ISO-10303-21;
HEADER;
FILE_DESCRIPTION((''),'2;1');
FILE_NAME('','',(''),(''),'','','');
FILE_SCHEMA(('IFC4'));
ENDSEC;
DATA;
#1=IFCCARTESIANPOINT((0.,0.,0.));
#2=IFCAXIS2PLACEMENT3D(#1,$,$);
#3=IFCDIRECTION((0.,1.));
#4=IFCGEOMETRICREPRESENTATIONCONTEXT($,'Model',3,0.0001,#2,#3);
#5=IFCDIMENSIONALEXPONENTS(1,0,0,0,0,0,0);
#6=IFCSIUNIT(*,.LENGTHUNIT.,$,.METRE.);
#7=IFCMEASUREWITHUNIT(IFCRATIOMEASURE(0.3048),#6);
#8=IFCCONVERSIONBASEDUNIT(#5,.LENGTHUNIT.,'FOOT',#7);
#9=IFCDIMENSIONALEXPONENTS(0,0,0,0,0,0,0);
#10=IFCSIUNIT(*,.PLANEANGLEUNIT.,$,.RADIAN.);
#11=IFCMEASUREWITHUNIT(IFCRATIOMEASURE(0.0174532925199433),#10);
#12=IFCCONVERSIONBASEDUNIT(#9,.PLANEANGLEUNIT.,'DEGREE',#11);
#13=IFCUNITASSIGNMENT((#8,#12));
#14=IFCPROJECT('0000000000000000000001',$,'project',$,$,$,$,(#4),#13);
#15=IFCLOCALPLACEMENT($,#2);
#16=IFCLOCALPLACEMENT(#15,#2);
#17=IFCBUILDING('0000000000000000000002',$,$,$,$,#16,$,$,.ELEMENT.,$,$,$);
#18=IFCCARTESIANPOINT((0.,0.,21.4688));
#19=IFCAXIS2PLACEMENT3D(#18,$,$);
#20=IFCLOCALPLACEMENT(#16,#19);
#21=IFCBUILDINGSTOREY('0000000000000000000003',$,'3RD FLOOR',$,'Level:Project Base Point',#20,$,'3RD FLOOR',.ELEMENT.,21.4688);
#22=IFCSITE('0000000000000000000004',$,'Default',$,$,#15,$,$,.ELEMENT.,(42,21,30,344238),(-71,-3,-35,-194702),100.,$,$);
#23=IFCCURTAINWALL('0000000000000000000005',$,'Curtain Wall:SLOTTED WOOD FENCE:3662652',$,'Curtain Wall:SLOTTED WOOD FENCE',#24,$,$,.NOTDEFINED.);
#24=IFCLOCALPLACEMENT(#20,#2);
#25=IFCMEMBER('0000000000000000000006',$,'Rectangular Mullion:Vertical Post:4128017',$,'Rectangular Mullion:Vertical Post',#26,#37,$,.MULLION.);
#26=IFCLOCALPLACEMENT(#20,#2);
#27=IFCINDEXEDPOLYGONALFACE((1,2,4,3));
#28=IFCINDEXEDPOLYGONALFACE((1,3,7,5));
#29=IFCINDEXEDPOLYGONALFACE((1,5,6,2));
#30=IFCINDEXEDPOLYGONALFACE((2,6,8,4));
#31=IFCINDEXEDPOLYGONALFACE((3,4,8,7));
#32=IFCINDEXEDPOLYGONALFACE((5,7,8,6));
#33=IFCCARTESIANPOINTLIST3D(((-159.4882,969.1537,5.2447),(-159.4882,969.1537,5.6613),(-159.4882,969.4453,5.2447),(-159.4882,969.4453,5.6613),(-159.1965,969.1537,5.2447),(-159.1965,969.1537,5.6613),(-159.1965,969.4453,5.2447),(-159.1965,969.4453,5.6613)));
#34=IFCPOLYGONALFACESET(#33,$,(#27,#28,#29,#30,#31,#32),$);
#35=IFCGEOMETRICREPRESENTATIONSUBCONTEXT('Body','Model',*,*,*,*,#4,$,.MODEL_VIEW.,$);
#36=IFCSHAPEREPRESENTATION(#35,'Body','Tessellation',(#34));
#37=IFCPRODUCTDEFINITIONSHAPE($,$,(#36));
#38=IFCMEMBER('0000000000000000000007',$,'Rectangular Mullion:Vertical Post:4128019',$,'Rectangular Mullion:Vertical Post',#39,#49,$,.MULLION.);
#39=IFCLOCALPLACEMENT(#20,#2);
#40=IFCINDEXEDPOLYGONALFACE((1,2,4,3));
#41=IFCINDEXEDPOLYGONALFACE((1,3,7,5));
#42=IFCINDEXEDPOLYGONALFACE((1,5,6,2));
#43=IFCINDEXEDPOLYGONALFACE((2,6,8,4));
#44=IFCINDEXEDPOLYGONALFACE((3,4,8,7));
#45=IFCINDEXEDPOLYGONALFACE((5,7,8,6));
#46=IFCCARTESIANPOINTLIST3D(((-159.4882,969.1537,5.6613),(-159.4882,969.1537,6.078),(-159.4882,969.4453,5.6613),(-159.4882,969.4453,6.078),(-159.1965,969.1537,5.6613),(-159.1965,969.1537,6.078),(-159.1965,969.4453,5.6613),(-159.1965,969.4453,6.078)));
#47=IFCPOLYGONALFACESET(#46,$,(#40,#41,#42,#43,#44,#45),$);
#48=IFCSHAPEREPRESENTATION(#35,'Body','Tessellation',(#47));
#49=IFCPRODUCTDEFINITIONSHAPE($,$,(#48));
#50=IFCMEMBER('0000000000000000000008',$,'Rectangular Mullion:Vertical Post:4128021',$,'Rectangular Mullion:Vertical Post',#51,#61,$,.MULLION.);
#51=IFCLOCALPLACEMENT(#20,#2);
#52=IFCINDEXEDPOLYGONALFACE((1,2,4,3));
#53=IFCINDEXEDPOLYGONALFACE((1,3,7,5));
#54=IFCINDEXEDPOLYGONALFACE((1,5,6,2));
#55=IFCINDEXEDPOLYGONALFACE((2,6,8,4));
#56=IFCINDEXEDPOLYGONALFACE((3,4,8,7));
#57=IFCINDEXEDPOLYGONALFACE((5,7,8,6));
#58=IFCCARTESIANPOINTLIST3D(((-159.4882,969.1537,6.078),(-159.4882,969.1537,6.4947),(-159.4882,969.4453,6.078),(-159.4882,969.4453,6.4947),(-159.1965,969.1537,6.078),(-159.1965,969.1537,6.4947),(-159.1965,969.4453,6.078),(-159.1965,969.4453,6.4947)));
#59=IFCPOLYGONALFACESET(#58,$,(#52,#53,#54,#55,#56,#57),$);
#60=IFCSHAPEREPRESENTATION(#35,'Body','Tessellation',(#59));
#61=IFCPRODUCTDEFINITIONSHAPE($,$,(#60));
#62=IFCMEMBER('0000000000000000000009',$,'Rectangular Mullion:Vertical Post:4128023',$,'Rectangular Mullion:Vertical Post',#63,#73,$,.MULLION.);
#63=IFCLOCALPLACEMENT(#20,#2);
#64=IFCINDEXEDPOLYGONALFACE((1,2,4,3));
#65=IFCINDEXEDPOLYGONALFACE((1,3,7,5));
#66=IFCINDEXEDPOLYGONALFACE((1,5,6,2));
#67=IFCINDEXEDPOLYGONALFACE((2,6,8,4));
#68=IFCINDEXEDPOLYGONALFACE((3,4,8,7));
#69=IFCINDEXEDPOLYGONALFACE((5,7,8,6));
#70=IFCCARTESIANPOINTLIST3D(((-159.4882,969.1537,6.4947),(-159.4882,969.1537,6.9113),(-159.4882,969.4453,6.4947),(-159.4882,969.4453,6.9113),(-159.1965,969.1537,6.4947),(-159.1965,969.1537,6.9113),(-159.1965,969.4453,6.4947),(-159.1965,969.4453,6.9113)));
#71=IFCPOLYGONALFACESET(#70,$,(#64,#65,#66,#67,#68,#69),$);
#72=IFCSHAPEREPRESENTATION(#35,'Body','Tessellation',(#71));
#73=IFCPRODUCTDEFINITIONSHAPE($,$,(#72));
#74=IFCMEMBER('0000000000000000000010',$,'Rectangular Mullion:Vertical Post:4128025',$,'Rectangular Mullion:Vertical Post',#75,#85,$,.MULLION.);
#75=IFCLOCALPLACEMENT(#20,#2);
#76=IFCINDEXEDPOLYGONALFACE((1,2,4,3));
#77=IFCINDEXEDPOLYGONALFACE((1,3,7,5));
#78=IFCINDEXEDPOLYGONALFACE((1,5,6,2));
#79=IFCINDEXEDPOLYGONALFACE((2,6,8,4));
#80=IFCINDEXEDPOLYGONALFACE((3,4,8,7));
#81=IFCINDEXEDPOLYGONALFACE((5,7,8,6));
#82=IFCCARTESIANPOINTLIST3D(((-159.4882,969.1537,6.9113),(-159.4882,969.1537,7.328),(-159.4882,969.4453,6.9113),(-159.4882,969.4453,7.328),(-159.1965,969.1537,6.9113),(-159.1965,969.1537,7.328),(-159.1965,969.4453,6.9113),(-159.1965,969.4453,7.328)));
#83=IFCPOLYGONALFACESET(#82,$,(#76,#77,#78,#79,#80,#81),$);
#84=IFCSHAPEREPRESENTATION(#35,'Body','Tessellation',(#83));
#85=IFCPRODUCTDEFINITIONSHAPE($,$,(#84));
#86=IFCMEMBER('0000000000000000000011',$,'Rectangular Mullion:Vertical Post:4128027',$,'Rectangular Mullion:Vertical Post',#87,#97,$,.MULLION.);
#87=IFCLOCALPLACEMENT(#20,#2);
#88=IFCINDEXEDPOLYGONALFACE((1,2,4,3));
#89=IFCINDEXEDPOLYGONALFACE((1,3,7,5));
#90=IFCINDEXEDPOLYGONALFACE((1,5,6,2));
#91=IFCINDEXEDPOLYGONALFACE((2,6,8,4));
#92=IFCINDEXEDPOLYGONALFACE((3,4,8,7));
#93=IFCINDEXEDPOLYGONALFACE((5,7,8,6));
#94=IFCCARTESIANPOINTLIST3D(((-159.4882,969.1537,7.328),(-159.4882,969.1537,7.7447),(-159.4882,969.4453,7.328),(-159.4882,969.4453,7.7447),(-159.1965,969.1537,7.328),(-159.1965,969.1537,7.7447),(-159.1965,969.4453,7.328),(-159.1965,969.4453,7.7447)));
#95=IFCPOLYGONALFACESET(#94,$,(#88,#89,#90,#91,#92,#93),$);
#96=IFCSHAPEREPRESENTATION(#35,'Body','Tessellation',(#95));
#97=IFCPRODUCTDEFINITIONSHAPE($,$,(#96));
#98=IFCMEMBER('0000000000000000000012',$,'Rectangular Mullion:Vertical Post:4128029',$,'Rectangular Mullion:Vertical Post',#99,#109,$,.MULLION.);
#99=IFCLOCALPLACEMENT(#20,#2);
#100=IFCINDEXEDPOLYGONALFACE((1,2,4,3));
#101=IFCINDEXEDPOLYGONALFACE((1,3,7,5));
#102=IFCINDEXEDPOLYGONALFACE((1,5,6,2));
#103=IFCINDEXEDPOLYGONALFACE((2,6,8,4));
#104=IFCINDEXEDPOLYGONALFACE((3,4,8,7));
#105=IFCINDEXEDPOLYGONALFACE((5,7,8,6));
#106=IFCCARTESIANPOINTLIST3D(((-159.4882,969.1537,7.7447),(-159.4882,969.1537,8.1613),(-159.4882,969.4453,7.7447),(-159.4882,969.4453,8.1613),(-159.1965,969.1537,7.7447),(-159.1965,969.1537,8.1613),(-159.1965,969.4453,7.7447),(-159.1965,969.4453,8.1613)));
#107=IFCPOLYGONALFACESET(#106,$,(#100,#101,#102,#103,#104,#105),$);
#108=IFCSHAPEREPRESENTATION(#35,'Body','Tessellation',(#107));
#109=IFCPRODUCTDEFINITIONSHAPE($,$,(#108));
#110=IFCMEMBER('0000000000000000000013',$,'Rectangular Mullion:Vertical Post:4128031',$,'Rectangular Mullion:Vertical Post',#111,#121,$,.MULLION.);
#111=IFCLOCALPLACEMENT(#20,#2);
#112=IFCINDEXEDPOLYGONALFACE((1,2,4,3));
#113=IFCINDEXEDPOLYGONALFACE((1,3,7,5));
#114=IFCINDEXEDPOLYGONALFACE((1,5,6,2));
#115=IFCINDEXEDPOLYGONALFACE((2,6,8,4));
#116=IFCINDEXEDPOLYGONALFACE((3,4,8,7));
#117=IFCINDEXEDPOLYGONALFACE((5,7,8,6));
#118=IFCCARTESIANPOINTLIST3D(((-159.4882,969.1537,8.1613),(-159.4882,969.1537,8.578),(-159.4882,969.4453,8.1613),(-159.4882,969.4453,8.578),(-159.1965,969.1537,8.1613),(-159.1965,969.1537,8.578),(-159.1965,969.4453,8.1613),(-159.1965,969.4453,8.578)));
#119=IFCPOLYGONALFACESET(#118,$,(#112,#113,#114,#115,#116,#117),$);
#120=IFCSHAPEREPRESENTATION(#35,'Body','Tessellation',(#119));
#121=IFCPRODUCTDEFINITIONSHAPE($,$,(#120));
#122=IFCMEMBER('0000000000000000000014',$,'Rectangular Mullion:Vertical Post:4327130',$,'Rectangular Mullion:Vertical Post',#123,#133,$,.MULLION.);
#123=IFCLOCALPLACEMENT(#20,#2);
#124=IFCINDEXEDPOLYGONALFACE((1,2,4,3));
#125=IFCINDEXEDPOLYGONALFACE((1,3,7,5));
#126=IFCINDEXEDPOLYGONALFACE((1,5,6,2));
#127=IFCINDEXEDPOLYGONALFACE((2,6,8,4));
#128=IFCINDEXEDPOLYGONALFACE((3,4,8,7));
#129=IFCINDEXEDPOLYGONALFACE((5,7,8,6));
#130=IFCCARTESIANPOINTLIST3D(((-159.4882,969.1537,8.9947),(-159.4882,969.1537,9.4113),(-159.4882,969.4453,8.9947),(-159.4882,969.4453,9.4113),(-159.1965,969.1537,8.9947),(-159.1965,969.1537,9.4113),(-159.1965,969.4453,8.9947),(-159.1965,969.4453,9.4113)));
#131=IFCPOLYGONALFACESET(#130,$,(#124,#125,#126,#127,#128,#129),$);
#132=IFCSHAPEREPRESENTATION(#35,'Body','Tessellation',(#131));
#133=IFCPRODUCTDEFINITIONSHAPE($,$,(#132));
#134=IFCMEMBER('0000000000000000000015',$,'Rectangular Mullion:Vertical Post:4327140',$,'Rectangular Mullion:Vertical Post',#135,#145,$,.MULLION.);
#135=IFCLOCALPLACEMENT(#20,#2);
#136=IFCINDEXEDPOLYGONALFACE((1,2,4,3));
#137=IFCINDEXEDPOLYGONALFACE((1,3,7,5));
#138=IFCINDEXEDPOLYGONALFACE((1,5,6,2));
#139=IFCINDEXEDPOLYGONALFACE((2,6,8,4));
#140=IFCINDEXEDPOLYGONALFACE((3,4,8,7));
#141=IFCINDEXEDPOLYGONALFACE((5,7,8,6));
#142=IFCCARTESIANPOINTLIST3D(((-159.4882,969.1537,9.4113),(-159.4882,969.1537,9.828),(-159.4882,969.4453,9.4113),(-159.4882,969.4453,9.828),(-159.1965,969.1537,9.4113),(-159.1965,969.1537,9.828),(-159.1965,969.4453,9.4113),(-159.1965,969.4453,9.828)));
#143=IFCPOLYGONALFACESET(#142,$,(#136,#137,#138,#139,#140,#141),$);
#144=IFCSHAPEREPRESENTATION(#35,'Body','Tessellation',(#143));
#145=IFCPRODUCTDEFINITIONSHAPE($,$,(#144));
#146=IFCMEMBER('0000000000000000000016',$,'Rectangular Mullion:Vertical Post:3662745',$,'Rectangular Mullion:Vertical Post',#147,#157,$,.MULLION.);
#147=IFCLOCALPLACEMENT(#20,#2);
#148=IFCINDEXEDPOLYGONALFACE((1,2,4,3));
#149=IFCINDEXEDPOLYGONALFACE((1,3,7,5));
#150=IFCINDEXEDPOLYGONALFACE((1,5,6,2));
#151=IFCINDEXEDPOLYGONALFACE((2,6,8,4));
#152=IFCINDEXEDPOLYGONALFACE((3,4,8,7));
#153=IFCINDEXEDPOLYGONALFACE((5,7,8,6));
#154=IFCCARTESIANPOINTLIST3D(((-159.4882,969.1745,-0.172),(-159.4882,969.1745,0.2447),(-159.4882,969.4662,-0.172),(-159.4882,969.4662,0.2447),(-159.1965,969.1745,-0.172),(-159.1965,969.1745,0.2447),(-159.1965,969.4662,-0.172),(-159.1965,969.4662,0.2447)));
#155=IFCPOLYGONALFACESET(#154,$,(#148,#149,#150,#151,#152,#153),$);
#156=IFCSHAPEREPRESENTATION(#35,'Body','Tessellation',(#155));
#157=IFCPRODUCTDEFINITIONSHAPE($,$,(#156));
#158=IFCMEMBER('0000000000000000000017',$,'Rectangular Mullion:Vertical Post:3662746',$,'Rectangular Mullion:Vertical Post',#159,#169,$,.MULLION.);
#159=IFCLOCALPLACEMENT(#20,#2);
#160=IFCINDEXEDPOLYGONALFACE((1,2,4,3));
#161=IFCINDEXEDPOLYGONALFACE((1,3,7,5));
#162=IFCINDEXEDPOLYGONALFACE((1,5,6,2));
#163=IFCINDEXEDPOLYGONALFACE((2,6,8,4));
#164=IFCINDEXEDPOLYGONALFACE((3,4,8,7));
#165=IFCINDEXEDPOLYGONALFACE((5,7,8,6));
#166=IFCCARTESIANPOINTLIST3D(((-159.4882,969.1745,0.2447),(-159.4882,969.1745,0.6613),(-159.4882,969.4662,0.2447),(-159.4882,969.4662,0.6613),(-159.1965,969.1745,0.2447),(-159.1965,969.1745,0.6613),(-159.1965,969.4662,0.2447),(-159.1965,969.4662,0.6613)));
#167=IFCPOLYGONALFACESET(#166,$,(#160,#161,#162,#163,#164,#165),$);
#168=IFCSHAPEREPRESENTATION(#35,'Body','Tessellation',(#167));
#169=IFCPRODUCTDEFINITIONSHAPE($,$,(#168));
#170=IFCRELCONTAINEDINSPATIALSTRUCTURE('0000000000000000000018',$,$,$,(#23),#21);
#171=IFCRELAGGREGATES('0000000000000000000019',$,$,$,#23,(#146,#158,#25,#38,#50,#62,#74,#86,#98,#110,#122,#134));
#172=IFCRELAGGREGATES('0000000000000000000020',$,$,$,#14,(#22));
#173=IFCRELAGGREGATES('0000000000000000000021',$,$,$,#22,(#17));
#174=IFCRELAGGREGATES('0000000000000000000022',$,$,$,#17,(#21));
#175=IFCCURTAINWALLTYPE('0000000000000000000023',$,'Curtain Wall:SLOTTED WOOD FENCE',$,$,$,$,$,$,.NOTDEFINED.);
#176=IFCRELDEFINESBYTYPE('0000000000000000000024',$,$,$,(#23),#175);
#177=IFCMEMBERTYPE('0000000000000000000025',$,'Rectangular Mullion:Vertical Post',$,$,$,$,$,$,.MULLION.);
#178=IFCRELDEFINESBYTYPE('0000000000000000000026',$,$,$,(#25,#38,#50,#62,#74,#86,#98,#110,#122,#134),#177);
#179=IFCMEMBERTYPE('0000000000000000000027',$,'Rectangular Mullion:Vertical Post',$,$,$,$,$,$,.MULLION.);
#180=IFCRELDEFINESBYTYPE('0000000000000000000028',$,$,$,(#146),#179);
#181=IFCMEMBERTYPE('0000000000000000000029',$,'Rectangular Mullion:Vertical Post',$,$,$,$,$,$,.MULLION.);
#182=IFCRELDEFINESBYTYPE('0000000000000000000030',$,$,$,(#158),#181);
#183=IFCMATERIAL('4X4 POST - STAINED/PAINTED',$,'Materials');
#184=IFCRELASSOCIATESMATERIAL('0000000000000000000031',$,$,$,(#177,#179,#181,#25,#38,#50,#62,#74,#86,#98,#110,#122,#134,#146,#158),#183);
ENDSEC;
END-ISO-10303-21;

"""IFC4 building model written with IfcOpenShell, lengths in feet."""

from ifc_helpers import new_model, entity, si_unit, converted_unit, direction, frame, origin, origin_2d_with_axis, place, context, subcontext, project, spatial, rectangle, extrude, source, transform, mapped, material, material_profile, profile_set, profile_usage, type_object, type_shapes, element, aggregate, save


model = new_model("IFC4")

# Units and contexts
model_context = context("Model", 3, precision=0.0001, world=origin(), true_north=direction((0.0, 1.0)))
body_context = subcontext(model_context, "Body", "Model", "MODEL_VIEW")
ifc_project = project(units=[converted_unit("LENGTHUNIT", "FOOT", entity("IfcRatioMeasure", 0.3048), si_unit("LENGTHUNIT", "METRE"), dimensions=[1, 0, 0, 0, 0, 0, 0]), converted_unit("PLANEANGLEUNIT", "DEGREE", entity("IfcRatioMeasure", 0.0174532925199433), si_unit("PLANEANGLEUNIT", "RADIAN"), dimensions=[0, 0, 0, 0, 0, 0, 0])], contexts=[model_context])

# Site, building, storey
site_placement = place(None, origin())
site = spatial("IfcSite", under=ifc_project, at=site_placement, Name="Default", CompositionType="ELEMENT", RefLatitude=(42, 21, 30, 344238), RefLongitude=(-71, -3, -35, -194702), RefElevation=100.0)
building_placement = place(site_placement, origin())
building = spatial("IfcBuilding", under=site, at=building_placement, CompositionType="ELEMENT")
storey_placement = place(building_placement, frame((0.0, 0.0, 21.4688)))
storey = spatial("IfcBuildingStorey", under=building, at=storey_placement, Name="3RD FLOOR", ObjectType="Level:Project Base Point", LongName="3RD FLOOR", CompositionType="ELEMENT", Elevation=21.4688)

# Curtain wall, members
curtain_wall_type = type_object("IfcCurtainWallType", Name="Curtain Wall:SLOTTED WOOD FENCE", PredefinedType="NOTDEFINED")
curtain_wall_placement = place(storey_placement, frame((0.0, 0.0, -21.4688)))
curtain_wall = element("IfcCurtainWall", 1, at=curtain_wall_placement, inside=storey, type_object=curtain_wall_type, Name="Curtain Wall:SLOTTED WOOD FENCE:3662652", ObjectType="Curtain Wall:SLOTTED WOOD FENCE", PredefinedType="NOTDEFINED")
ifc_material = material(Name="4X4 POST - STAINED/PAINTED", Category="Materials")
ifc_material_profile = material_profile(ifc_material, rectangle(XDim=0.2917, YDim=0.2917, at=origin_2d_with_axis()), Name="Vertical Post")
ifc_profile_set = profile_set([ifc_material_profile], Name="Vertical Post")
member_type_1 = type_object("IfcMemberType", Name="Rectangular Mullion:Vertical Post", PredefinedType="MULLION", material=ifc_profile_set)
shared_shape_1 = source(origin(), body_context, "Body", "SweptSolid", [
    extrude(rectangle(XDim=0.2917, YDim=0.2917, at=origin_2d_with_axis()), frame((0.0, -0.2083, -0.4167), z_axis=(0.0, 0.0, 1.0), x_axis=(0.0, -1.0, 0.0)), (0.0, 0.0, 1.0), 0.4167),
])
type_shapes(member_type_1, [shared_shape_1])
ifc_profile_usage_1 = profile_usage(ifc_profile_set)
member_1_placement = place(storey_placement, frame((-159.5507, 969.2995, 5.2447), z_axis=(0.0, 0.0, -1.0), x_axis=(0.0, -1.0, 0.0)))
member_1 = element("IfcMember", 2, at=member_1_placement, type_object=member_type_1, material=ifc_profile_usage_1, Name="Rectangular Mullion:Vertical Post:4128017", ObjectType="Rectangular Mullion:Vertical Post", PredefinedType="MULLION", context=body_context, shape_type="MappedRepresentation", body=[
    mapped(shared_shape_1, transform((0.0, 0.0, 0.0), scale=1.0)),
])
ifc_profile_usage_2 = profile_usage(ifc_profile_set)
member_2_placement = place(storey_placement, frame((-159.5507, 969.2995, 5.6613), z_axis=(0.0, 0.0, -1.0), x_axis=(0.0, -1.0, 0.0)))
member_2 = element("IfcMember", 3, at=member_2_placement, type_object=member_type_1, material=ifc_profile_usage_2, Name="Rectangular Mullion:Vertical Post:4128019", ObjectType="Rectangular Mullion:Vertical Post", PredefinedType="MULLION", context=body_context, shape_type="MappedRepresentation", body=[
    mapped(shared_shape_1, transform((0.0, 0.0, 0.0), scale=1.0)),
])
ifc_profile_usage_3 = profile_usage(ifc_profile_set)
member_3_placement = place(storey_placement, frame((-159.5507, 969.2995, 6.078), z_axis=(0.0, 0.0, -1.0), x_axis=(0.0, -1.0, 0.0)))
member_3 = element("IfcMember", 4, at=member_3_placement, type_object=member_type_1, material=ifc_profile_usage_3, Name="Rectangular Mullion:Vertical Post:4128021", ObjectType="Rectangular Mullion:Vertical Post", PredefinedType="MULLION", context=body_context, shape_type="MappedRepresentation", body=[
    mapped(shared_shape_1, transform((0.0, 0.0, 0.0), scale=1.0)),
])
ifc_profile_usage_4 = profile_usage(ifc_profile_set)
member_4_placement = place(storey_placement, frame((-159.5507, 969.2995, 6.4947), z_axis=(0.0, 0.0, -1.0), x_axis=(0.0, -1.0, 0.0)))
member_4 = element("IfcMember", 5, at=member_4_placement, type_object=member_type_1, material=ifc_profile_usage_4, Name="Rectangular Mullion:Vertical Post:4128023", ObjectType="Rectangular Mullion:Vertical Post", PredefinedType="MULLION", context=body_context, shape_type="MappedRepresentation", body=[
    mapped(shared_shape_1, transform((0.0, 0.0, 0.0), scale=1.0)),
])
ifc_profile_usage_5 = profile_usage(ifc_profile_set)
member_5_placement = place(storey_placement, frame((-159.5507, 969.2995, 6.9113), z_axis=(0.0, 0.0, -1.0), x_axis=(0.0, -1.0, 0.0)))
member_5 = element("IfcMember", 6, at=member_5_placement, type_object=member_type_1, material=ifc_profile_usage_5, Name="Rectangular Mullion:Vertical Post:4128025", ObjectType="Rectangular Mullion:Vertical Post", PredefinedType="MULLION", context=body_context, shape_type="MappedRepresentation", body=[
    mapped(shared_shape_1, transform((0.0, 0.0, 0.0), scale=1.0)),
])
ifc_profile_usage_6 = profile_usage(ifc_profile_set)
member_6_placement = place(storey_placement, frame((-159.5507, 969.2995, 7.328), z_axis=(0.0, 0.0, -1.0), x_axis=(0.0, -1.0, 0.0)))
member_6 = element("IfcMember", 7, at=member_6_placement, type_object=member_type_1, material=ifc_profile_usage_6, Name="Rectangular Mullion:Vertical Post:4128027", ObjectType="Rectangular Mullion:Vertical Post", PredefinedType="MULLION", context=body_context, shape_type="MappedRepresentation", body=[
    mapped(shared_shape_1, transform((0.0, 0.0, 0.0), scale=1.0)),
])
ifc_profile_usage_7 = profile_usage(ifc_profile_set)
member_7_placement = place(storey_placement, frame((-159.5507, 969.2995, 7.7447), z_axis=(0.0, 0.0, -1.0), x_axis=(0.0, -1.0, 0.0)))
member_7 = element("IfcMember", 8, at=member_7_placement, type_object=member_type_1, material=ifc_profile_usage_7, Name="Rectangular Mullion:Vertical Post:4128029", ObjectType="Rectangular Mullion:Vertical Post", PredefinedType="MULLION", context=body_context, shape_type="MappedRepresentation", body=[
    mapped(shared_shape_1, transform((0.0, 0.0, 0.0), scale=1.0)),
])
ifc_profile_usage_8 = profile_usage(ifc_profile_set)
member_8_placement = place(storey_placement, frame((-159.5507, 969.2995, 8.1613), z_axis=(0.0, 0.0, -1.0), x_axis=(0.0, -1.0, 0.0)))
member_8 = element("IfcMember", 9, at=member_8_placement, type_object=member_type_1, material=ifc_profile_usage_8, Name="Rectangular Mullion:Vertical Post:4128031", ObjectType="Rectangular Mullion:Vertical Post", PredefinedType="MULLION", context=body_context, shape_type="MappedRepresentation", body=[
    mapped(shared_shape_1, transform((0.0, 0.0, 0.0), scale=1.0)),
])
ifc_profile_usage_9 = profile_usage(ifc_profile_set)
member_9_placement = place(storey_placement, frame((-159.5507, 969.2995, 8.9947), z_axis=(0.0, 0.0, -1.0), x_axis=(0.0, -1.0, 0.0)))
member_9 = element("IfcMember", 10, at=member_9_placement, type_object=member_type_1, material=ifc_profile_usage_9, Name="Rectangular Mullion:Vertical Post:4327130", ObjectType="Rectangular Mullion:Vertical Post", PredefinedType="MULLION", context=body_context, shape_type="MappedRepresentation", body=[
    mapped(shared_shape_1, transform((0.0, 0.0, 0.0), scale=1.0)),
])
ifc_profile_usage_10 = profile_usage(ifc_profile_set)
member_10_placement = place(storey_placement, frame((-159.5507, 969.2995, 9.4113), z_axis=(0.0, 0.0, -1.0), x_axis=(0.0, -1.0, 0.0)))
member_10 = element("IfcMember", 11, at=member_10_placement, type_object=member_type_1, material=ifc_profile_usage_10, Name="Rectangular Mullion:Vertical Post:4327140", ObjectType="Rectangular Mullion:Vertical Post", PredefinedType="MULLION", context=body_context, shape_type="MappedRepresentation", body=[
    mapped(shared_shape_1, transform((0.0, 0.0, 0.0), scale=1.0)),
])
ifc_profile_usage_11 = profile_usage(ifc_profile_set)
member_type_2 = type_object("IfcMemberType", Name="Rectangular Mullion:Vertical Post", PredefinedType="MULLION", material=ifc_profile_set)
shared_shape_2 = source(origin(), body_context, "Body", "SweptSolid", [
    extrude(rectangle(XDim=0.2917, YDim=0.2917, at=origin_2d_with_axis()), frame((-0.1458, -0.2083, -0.4167), z_axis=(0.0, 0.0, 1.0), x_axis=(0.0, -1.0, 0.0)), (0.0, 0.0, 1.0), 0.4167),
])
type_shapes(member_type_2, [shared_shape_2])
member_11_placement = place(storey_placement, frame((-159.5507, 969.4662, 0.2447), z_axis=(0.0, 0.0, 1.0), x_axis=(0.0, 1.0, 0.0)))
member_11 = element("IfcMember", 12, at=member_11_placement, type_object=member_type_2, material=ifc_profile_usage_11, Name="Rectangular Mullion:Vertical Post:3662745", ObjectType="Rectangular Mullion:Vertical Post", PredefinedType="MULLION", context=body_context, shape_type="MappedRepresentation", body=[
    mapped(shared_shape_2, transform((0.0, 0.0, 0.0), scale=1.0)),
])
ifc_profile_usage_12 = profile_usage(ifc_profile_set)
member_type_3 = type_object("IfcMemberType", Name="Rectangular Mullion:Vertical Post", PredefinedType="MULLION", material=ifc_profile_set)
shared_shape_3 = source(origin(), body_context, "Body", "SweptSolid", [
    extrude(rectangle(XDim=0.2917, YDim=0.2917, at=origin_2d_with_axis()), frame((-0.1458, -0.2083, -0.4167), z_axis=(0.0, 0.0, 1.0), x_axis=(0.0, -1.0, 0.0)), (0.0, 0.0, 1.0), 0.4167),
])
type_shapes(member_type_3, [shared_shape_3])
member_12_placement = place(storey_placement, frame((-159.5507, 969.4662, 0.6613), z_axis=(0.0, 0.0, 1.0), x_axis=(0.0, 1.0, 0.0)))
member_12 = element("IfcMember", 13, at=member_12_placement, type_object=member_type_3, material=ifc_profile_usage_12, Name="Rectangular Mullion:Vertical Post:3662746", ObjectType="Rectangular Mullion:Vertical Post", PredefinedType="MULLION", context=body_context, shape_type="MappedRepresentation", body=[
    mapped(shared_shape_3, transform((0.0, 0.0, 0.0), scale=1.0)),
])
aggregate(curtain_wall, [member_11, member_12, member_1, member_2, member_3, member_4, member_5, member_6, member_7, member_8, member_9, member_10])

save(model, "model.ifc")
